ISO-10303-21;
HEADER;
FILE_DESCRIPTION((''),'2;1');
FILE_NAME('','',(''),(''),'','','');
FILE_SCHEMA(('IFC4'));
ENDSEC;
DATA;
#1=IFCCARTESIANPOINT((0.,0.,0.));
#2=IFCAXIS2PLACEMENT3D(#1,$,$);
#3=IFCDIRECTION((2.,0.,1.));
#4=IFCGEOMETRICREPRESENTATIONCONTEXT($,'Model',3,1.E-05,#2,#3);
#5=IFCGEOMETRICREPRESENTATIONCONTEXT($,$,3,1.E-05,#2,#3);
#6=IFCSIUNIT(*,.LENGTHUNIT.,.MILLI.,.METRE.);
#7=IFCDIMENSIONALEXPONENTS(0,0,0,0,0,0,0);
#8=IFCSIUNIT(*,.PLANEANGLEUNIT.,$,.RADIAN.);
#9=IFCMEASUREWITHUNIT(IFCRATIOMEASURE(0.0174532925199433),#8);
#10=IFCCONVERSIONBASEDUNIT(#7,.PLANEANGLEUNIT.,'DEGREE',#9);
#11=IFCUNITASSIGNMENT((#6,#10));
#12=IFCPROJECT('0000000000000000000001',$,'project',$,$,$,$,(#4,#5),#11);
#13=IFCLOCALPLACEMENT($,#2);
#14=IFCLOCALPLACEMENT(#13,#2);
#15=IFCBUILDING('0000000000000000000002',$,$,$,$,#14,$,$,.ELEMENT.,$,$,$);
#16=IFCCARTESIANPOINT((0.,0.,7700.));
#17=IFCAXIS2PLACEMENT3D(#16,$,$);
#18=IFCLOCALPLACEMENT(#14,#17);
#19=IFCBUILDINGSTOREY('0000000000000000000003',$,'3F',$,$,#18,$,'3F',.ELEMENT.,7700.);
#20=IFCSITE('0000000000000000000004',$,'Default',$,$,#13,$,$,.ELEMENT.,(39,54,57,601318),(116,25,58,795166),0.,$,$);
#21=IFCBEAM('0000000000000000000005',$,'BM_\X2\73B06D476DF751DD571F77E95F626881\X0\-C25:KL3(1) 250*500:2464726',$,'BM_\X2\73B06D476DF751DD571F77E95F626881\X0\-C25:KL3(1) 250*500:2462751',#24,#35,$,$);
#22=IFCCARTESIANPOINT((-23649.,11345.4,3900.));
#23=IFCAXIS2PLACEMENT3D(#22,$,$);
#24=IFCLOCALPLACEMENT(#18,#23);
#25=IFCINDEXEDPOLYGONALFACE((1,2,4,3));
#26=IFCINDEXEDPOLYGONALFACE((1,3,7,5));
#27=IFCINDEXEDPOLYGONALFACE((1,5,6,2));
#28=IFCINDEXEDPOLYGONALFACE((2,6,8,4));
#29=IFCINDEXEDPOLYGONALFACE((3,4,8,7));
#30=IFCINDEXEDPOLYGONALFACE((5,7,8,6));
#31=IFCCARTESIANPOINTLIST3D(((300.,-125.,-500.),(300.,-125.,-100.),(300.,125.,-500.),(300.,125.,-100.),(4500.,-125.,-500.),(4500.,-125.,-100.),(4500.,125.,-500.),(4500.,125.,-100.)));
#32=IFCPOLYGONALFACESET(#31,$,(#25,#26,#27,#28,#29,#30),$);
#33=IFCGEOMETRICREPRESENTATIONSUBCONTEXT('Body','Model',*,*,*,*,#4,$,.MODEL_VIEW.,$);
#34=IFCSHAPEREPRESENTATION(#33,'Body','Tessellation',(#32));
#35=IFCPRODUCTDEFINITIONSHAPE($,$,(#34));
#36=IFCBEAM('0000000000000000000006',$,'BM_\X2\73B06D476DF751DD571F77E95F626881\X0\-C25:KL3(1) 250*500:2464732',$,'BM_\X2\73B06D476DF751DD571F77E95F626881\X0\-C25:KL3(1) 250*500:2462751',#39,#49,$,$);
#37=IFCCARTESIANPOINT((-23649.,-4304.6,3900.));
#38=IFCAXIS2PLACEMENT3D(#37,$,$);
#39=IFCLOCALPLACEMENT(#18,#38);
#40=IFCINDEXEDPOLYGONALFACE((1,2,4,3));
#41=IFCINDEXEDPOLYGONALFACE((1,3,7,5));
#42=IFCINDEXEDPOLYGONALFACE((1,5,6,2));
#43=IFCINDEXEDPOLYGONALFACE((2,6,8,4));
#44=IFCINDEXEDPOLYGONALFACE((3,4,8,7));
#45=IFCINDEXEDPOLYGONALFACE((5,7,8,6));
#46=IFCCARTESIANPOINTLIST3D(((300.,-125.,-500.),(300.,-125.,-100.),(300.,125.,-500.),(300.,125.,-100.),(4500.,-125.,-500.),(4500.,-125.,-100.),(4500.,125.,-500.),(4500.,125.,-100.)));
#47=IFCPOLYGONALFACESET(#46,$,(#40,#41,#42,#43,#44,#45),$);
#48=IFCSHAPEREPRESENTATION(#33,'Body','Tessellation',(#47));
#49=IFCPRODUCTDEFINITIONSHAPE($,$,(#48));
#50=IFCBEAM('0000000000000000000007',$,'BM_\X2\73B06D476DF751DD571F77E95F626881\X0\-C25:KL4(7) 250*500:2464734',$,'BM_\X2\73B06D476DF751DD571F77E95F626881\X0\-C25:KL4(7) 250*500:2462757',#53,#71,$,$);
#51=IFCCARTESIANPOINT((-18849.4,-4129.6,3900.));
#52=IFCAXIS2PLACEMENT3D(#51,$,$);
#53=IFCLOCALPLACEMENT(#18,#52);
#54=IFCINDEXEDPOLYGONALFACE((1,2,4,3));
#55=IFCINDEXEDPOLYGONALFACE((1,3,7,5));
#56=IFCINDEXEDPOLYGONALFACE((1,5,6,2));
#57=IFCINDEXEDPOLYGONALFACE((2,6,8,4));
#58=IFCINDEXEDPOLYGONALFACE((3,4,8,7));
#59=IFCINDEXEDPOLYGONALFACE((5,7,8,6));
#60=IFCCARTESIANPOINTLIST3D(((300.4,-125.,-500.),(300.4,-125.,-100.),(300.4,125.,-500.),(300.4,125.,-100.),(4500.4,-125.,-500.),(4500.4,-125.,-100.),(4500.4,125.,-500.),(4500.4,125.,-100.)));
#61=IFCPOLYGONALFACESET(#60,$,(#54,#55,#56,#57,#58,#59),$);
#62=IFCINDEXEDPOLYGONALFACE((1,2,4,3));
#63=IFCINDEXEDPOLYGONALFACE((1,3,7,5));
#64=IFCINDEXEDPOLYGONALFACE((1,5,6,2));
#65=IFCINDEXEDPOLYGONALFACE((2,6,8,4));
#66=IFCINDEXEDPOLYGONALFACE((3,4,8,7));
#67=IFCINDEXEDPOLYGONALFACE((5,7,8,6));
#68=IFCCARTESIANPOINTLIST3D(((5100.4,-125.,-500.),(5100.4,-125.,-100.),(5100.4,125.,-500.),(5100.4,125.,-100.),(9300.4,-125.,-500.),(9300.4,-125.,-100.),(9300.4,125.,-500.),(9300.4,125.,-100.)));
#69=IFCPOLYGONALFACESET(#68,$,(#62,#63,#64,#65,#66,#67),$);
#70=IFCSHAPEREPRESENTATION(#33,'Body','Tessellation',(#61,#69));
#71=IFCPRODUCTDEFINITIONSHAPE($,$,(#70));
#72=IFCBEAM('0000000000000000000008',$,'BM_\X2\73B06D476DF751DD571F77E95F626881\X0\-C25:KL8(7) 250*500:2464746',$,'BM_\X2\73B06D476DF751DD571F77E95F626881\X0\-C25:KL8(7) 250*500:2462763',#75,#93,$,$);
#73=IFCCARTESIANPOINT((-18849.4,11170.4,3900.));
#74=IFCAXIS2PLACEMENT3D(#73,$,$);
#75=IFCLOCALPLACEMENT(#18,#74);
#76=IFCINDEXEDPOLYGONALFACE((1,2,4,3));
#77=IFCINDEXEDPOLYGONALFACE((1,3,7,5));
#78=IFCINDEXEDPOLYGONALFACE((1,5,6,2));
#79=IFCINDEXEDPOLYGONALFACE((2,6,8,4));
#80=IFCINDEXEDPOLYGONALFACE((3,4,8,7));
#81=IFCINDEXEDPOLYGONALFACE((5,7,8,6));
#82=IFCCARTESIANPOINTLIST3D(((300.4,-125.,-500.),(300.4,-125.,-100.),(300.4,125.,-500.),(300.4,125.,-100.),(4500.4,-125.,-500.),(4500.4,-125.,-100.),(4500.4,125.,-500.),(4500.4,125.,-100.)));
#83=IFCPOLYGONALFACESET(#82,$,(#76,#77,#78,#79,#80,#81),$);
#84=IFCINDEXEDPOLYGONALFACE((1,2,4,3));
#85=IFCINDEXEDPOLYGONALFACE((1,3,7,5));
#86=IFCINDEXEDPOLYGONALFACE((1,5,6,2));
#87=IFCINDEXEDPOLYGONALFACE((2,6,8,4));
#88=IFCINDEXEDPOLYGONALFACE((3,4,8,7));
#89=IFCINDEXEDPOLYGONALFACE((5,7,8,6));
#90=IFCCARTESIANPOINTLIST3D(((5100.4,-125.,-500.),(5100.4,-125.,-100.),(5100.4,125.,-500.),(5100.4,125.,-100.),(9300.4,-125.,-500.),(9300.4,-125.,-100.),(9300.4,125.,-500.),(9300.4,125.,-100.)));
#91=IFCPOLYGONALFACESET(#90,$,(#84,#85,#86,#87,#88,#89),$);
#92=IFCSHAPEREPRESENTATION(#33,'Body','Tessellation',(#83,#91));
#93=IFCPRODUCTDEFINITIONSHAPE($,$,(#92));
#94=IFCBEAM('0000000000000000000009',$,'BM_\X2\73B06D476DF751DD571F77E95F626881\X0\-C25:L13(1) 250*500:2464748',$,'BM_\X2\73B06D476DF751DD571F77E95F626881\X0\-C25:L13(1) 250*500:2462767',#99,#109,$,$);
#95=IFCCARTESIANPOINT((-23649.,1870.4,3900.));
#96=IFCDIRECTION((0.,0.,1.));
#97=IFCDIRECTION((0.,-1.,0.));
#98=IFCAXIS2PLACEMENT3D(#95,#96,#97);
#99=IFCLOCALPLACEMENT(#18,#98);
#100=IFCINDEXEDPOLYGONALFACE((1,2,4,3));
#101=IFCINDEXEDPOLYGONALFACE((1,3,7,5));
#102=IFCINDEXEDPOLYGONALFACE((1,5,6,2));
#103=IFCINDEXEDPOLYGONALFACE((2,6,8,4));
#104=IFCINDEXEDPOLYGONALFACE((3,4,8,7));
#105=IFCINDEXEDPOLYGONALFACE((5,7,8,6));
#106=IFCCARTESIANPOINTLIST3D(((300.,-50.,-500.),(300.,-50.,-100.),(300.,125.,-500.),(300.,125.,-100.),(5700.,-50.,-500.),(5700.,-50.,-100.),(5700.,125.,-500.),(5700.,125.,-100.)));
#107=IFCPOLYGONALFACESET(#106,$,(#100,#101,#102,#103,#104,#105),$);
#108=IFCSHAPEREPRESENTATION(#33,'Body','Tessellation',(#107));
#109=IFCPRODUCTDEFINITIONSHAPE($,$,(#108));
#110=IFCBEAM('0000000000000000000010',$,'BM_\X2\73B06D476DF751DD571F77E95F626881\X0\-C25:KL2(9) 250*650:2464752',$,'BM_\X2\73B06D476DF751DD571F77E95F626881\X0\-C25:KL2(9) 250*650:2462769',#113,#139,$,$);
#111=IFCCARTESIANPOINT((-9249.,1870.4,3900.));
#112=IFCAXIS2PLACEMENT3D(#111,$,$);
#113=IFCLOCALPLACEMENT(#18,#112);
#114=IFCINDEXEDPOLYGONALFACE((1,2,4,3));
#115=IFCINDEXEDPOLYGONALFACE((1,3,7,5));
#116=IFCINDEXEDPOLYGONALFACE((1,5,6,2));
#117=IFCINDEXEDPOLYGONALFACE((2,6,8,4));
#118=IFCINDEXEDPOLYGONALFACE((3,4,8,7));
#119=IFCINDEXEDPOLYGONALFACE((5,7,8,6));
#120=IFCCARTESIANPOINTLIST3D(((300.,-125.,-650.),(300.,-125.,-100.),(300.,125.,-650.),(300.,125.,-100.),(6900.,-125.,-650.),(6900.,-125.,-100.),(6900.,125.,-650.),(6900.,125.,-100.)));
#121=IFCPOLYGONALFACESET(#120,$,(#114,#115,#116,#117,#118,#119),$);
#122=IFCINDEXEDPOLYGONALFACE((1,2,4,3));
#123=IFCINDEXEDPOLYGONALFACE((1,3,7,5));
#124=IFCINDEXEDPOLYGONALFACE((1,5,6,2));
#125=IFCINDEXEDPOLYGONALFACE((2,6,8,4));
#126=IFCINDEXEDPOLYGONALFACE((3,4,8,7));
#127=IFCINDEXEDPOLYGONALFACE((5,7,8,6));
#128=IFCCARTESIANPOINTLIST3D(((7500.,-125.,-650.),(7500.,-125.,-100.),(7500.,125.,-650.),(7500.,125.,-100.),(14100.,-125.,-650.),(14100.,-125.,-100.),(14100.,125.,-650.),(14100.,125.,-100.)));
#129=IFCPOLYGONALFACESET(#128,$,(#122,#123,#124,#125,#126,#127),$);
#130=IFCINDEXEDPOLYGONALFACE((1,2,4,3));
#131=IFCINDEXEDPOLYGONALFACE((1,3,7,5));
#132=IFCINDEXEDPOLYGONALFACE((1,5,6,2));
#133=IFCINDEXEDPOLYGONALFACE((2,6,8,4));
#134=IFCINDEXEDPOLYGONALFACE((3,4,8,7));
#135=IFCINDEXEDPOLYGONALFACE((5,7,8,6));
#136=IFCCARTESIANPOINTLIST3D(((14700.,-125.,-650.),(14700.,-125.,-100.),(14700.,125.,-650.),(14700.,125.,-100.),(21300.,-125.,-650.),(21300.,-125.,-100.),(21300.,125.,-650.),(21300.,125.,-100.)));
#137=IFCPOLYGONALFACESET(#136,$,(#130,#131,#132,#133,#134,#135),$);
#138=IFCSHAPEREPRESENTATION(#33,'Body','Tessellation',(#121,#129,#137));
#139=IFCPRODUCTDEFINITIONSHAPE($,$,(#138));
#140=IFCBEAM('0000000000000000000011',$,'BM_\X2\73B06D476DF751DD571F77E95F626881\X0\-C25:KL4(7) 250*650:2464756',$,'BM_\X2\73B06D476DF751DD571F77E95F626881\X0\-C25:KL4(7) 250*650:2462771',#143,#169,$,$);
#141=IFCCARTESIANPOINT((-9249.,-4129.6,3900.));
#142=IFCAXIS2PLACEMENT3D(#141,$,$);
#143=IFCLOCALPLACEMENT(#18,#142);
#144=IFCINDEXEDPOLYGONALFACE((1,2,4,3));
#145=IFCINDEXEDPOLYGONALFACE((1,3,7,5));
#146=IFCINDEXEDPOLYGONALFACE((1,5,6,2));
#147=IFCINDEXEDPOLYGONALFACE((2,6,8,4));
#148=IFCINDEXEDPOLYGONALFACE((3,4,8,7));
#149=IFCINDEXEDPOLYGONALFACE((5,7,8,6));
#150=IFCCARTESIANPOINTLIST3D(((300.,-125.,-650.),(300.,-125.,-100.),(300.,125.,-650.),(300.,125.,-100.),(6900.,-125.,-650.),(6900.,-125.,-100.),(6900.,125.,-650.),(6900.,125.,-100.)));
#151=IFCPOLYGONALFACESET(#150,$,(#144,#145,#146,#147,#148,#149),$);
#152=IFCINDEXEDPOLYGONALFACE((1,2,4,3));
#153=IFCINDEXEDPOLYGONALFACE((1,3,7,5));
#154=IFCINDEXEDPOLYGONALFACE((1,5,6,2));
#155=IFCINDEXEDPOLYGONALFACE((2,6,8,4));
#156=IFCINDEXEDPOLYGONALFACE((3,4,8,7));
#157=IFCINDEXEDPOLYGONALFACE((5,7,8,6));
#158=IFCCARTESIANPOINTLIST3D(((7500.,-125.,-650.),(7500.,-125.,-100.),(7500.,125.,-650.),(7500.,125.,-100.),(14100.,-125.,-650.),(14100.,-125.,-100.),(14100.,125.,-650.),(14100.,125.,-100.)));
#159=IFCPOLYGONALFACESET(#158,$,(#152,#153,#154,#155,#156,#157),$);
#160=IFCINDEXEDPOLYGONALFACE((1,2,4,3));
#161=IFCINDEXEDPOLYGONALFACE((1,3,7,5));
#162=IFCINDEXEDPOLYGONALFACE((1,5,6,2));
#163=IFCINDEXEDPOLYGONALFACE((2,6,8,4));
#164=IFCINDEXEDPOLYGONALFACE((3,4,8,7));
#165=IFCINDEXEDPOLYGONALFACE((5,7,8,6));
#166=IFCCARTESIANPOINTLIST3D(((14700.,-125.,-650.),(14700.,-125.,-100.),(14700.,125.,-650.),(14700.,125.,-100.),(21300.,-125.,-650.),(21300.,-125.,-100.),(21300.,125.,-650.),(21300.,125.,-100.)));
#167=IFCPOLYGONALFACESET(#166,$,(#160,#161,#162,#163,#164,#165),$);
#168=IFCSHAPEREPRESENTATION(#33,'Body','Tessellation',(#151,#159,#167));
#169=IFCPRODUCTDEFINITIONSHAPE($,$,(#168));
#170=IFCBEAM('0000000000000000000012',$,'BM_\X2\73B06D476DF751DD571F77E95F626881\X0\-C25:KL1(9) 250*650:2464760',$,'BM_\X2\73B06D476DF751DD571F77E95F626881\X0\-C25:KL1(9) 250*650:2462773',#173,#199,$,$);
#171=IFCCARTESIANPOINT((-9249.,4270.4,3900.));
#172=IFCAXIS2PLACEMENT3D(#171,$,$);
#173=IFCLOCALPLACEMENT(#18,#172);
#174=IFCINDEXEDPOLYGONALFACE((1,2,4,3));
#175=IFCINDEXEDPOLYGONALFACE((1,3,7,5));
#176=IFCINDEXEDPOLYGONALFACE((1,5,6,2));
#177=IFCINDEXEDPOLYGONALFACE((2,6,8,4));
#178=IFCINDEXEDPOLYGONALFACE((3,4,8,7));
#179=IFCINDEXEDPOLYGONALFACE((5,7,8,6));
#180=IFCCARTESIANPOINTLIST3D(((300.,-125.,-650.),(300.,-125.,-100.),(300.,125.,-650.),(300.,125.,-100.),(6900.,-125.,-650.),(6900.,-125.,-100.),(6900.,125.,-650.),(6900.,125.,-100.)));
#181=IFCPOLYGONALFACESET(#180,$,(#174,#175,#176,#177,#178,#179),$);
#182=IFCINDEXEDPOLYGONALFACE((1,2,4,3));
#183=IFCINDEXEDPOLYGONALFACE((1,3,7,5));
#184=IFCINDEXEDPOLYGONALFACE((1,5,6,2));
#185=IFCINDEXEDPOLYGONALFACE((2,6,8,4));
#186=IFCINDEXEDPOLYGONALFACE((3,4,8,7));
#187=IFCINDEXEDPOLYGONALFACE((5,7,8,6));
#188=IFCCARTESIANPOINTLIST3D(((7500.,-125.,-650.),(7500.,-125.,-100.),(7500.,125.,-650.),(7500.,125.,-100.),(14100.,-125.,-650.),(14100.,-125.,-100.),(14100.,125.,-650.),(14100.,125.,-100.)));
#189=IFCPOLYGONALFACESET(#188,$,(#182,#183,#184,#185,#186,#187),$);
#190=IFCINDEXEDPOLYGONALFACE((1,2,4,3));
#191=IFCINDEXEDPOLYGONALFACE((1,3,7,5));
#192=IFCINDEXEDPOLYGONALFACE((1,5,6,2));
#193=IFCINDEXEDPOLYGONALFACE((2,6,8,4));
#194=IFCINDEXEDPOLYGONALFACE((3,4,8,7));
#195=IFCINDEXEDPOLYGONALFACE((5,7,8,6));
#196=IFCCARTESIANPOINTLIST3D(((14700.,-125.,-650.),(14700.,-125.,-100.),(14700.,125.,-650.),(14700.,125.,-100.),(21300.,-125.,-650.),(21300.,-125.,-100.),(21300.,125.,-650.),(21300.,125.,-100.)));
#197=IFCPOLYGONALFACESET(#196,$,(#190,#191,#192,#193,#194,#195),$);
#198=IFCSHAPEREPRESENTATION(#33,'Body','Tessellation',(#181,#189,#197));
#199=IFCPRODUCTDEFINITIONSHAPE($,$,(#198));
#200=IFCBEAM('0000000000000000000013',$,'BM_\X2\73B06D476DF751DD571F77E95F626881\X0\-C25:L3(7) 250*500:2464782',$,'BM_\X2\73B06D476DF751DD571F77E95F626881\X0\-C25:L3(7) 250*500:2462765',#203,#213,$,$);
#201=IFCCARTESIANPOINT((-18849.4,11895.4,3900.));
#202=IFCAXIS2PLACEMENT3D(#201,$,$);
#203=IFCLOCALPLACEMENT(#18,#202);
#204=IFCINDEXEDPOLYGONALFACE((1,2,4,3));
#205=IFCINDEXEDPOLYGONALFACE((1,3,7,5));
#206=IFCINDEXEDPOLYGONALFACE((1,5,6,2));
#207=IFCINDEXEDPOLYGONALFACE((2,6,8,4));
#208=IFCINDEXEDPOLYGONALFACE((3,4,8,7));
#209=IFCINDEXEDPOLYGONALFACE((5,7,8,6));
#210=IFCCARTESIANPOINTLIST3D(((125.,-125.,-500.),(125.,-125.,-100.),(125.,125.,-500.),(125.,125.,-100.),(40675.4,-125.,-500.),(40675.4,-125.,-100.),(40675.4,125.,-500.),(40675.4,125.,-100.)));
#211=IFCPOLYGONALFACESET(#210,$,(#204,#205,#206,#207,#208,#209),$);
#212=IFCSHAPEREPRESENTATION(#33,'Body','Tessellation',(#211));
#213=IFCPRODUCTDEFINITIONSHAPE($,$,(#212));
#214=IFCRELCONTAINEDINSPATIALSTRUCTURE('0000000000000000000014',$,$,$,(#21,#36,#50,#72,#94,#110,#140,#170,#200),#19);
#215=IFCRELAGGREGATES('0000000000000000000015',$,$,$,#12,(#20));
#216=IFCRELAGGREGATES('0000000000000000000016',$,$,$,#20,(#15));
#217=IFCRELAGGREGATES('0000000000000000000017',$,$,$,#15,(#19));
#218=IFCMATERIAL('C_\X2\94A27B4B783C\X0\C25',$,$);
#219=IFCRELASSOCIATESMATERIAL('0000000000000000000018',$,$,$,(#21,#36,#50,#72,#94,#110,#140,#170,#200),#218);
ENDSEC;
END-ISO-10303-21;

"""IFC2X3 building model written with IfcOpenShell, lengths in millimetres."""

from ifc_helpers import new_model, entity, si_unit, converted_unit, direction, frame, frame_2d, origin, origin_2d_with_axis, place, context, subcontext, project, spatial, rectangle, extrude, material, element, save


model = new_model("IFC2X3")

# Units and contexts
model_context = context("Model", 3, precision=1e-05, world=origin(), true_north=direction((2.0, 0.0, 1.0)))
context_of_model = context(None, 3, precision=1e-05, world=origin(), true_north=direction((2.0, 0.0, 1.0)))
body_context = subcontext(model_context, "Body", "Model", "MODEL_VIEW")
ifc_project = project(units=[si_unit("LENGTHUNIT", "METRE", prefix="MILLI"), converted_unit("PLANEANGLEUNIT", "DEGREE", entity("IfcRatioMeasure", 0.0174532925199433), si_unit("PLANEANGLEUNIT", "RADIAN"), dimensions=[0, 0, 0, 0, 0, 0, 0])], contexts=[model_context, context_of_model])

# Site, building, storey
site_placement = place(None, origin())
site = spatial("IfcSite", under=ifc_project, at=site_placement, Name="Default", CompositionType="ELEMENT", RefLatitude=(39, 54, 57, 601318), RefLongitude=(116, 25, 58, 795166), RefElevation=0.0)
building_placement = place(site_placement, origin())
building = spatial("IfcBuilding", under=site, at=building_placement, CompositionType="ELEMENT")
storey_placement = place(building_placement, frame((0.0, 0.0, 7700.0)))
storey = spatial("IfcBuildingStorey", under=building, at=storey_placement, Name="3F", LongName="3F", CompositionType="ELEMENT", Elevation=7700.0)

# Beams
ifc_material = material(Name="C_钢筋砼C25")
beam_1_placement = place(storey_placement, frame((-23649.0, 11345.4, 3900.0)))
element("IfcBeam", 1, at=beam_1_placement, inside=storey, material=ifc_material, Name="BM_现浇混凝土矩形梁-C25:KL3(1) 250*500:2464726", ObjectType="BM_现浇混凝土矩形梁-C25:KL3(1) 250*500:2462751", context=body_context, shape_type="SweptSolid", body=[
    extrude(rectangle(XDim=400.0, YDim=250.0, at=frame_2d((0.0, 0.0), x_axis=(1.0, 0.0))), frame((300.0, 0.0, -300.0), z_axis=(1.0, 0.0, 0.0), x_axis=(0.0, 0.0, -1.0)), (0.0, 0.0, 1.0), 4200.0),
])
beam_2_placement = place(storey_placement, frame((-23649.0, -4304.6, 3900.0)))
element("IfcBeam", 2, at=beam_2_placement, inside=storey, material=ifc_material, Name="BM_现浇混凝土矩形梁-C25:KL3(1) 250*500:2464732", ObjectType="BM_现浇混凝土矩形梁-C25:KL3(1) 250*500:2462751", context=body_context, shape_type="SweptSolid", body=[
    extrude(rectangle(XDim=400.0, YDim=250.0, at=frame_2d((0.0, 0.0), x_axis=(1.0, 0.0))), frame((300.0, 0.0, -300.0), z_axis=(1.0, 0.0, 0.0), x_axis=(0.0, 0.0, -1.0)), (0.0, 0.0, 1.0), 4200.0),
])
beam_3_placement = place(storey_placement, frame((-18849.4, -4129.6, 3900.0)))
element("IfcBeam", 3, at=beam_3_placement, inside=storey, material=ifc_material, Name="BM_现浇混凝土矩形梁-C25:KL4(7) 250*500:2464734", ObjectType="BM_现浇混凝土矩形梁-C25:KL4(7) 250*500:2462757", context=body_context, shape_type="SweptSolid", body=[
    extrude(rectangle(XDim=400.0, YDim=250.0, at=frame_2d((0.0, 0.0), x_axis=(1.0, 0.0))), frame((300.4, 0.0, -300.0), z_axis=(1.0, 0.0, 0.0), x_axis=(0.0, 0.0, 1.0)), (0.0, 0.0, 1.0), 4200.0),
    extrude(rectangle(XDim=400.0, YDim=250.0, at=origin_2d_with_axis()), frame((5100.4, 0.0, -300.0), z_axis=(1.0, 0.0, 0.0), x_axis=(0.0, 0.0, 1.0)), (0.0, 0.0, 1.0), 4200.0),
])
beam_4_placement = place(storey_placement, frame((-18849.4, 11170.4, 3900.0)))
element("IfcBeam", 4, at=beam_4_placement, inside=storey, material=ifc_material, Name="BM_现浇混凝土矩形梁-C25:KL8(7) 250*500:2464746", ObjectType="BM_现浇混凝土矩形梁-C25:KL8(7) 250*500:2462763", context=body_context, shape_type="SweptSolid", body=[
    extrude(rectangle(XDim=400.0, YDim=250.0, at=origin_2d_with_axis()), frame((300.4, 0.0, -300.0), z_axis=(1.0, 0.0, 0.0), x_axis=(0.0, 0.0, 1.0)), (0.0, 0.0, 1.0), 4200.0),
    extrude(rectangle(XDim=400.0, YDim=250.0, at=origin_2d_with_axis()), frame((5100.4, 0.0, -300.0), z_axis=(1.0, 0.0, 0.0), x_axis=(0.0, 0.0, 1.0)), (0.0, 0.0, 1.0), 4200.0),
])
beam_5_placement = place(storey_placement, frame((-23649.0, 1870.4, 3900.0), z_axis=(0.0, 0.0, 1.0), x_axis=(0.0, -1.0, 0.0)))
element("IfcBeam", 5, at=beam_5_placement, inside=storey, material=ifc_material, Name="BM_现浇混凝土矩形梁-C25:L13(1) 250*500:2464748", ObjectType="BM_现浇混凝土矩形梁-C25:L13(1) 250*500:2462767", context=body_context, shape_type="SweptSolid", body=[
    extrude(rectangle(XDim=400.0, YDim=175.0, at=origin_2d_with_axis()), frame((300.0, 37.5, -300.0), z_axis=(1.0, 0.0, 0.0), x_axis=(0.0, 0.0, -1.0)), (0.0, 0.0, 1.0), 5400.0),
])
beam_6_placement = place(storey_placement, frame((-9249.0, 1870.4, 3900.0)))
element("IfcBeam", 6, at=beam_6_placement, inside=storey, material=ifc_material, Name="BM_现浇混凝土矩形梁-C25:KL2(9) 250*650:2464752", ObjectType="BM_现浇混凝土矩形梁-C25:KL2(9) 250*650:2462769", context=body_context, shape_type="SweptSolid", body=[
    extrude(rectangle(XDim=550.0, YDim=250.0, at=frame_2d((0.0, 0.0), x_axis=(1.0, 0.0))), frame((300.0, 0.0, -375.0), z_axis=(1.0, 0.0, 0.0), x_axis=(0.0, 0.0, 1.0)), (0.0, 0.0, 1.0), 6600.0),
    extrude(rectangle(XDim=550.0, YDim=250.0, at=frame_2d((0.0, 0.0), x_axis=(1.0, 0.0))), frame((7500.0, 0.0, -375.0), z_axis=(1.0, 0.0, 0.0), x_axis=(0.0, 0.0, 1.0)), (0.0, 0.0, 1.0), 6600.0),
    extrude(rectangle(XDim=550.0, YDim=250.0, at=frame_2d((0.0, 0.0), x_axis=(1.0, 0.0))), frame((14700.0, 0.0, -375.0), z_axis=(1.0, 0.0, 0.0), x_axis=(0.0, 0.0, 1.0)), (0.0, 0.0, 1.0), 6600.0),
])
beam_7_placement = place(storey_placement, frame((-9249.0, -4129.6, 3900.0)))
element("IfcBeam", 7, at=beam_7_placement, inside=storey, material=ifc_material, Name="BM_现浇混凝土矩形梁-C25:KL4(7) 250*650:2464756", ObjectType="BM_现浇混凝土矩形梁-C25:KL4(7) 250*650:2462771", context=body_context, shape_type="SweptSolid", body=[
    extrude(rectangle(XDim=550.0, YDim=250.0, at=frame_2d((0.0, 0.0), x_axis=(1.0, 0.0))), frame((300.0, 0.0, -375.0), z_axis=(1.0, 0.0, 0.0), x_axis=(0.0, 0.0, 1.0)), (0.0, 0.0, 1.0), 6600.0),
    extrude(rectangle(XDim=550.0, YDim=250.0, at=frame_2d((0.0, 0.0), x_axis=(1.0, 0.0))), frame((7500.0, 0.0, -375.0), z_axis=(1.0, 0.0, 0.0), x_axis=(0.0, 0.0, 1.0)), (0.0, 0.0, 1.0), 6600.0),
    extrude(rectangle(XDim=550.0, YDim=250.0, at=frame_2d((0.0, 0.0), x_axis=(1.0, 0.0))), frame((14700.0, 0.0, -375.0), z_axis=(1.0, 0.0, 0.0), x_axis=(0.0, 0.0, 1.0)), (0.0, 0.0, 1.0), 6600.0),
])
beam_8_placement = place(storey_placement, frame((-9249.0, 4270.4, 3900.0)))
element("IfcBeam", 8, at=beam_8_placement, inside=storey, material=ifc_material, Name="BM_现浇混凝土矩形梁-C25:KL1(9) 250*650:2464760", ObjectType="BM_现浇混凝土矩形梁-C25:KL1(9) 250*650:2462773", context=body_context, shape_type="SweptSolid", body=[
    extrude(rectangle(XDim=550.0, YDim=250.0, at=frame_2d((0.0, 0.0), x_axis=(1.0, 0.0))), frame((300.0, 0.0, -375.0), z_axis=(1.0, 0.0, 0.0), x_axis=(0.0, 0.0, 1.0)), (0.0, 0.0, 1.0), 6600.0),
    extrude(rectangle(XDim=550.0, YDim=250.0, at=frame_2d((0.0, 0.0), x_axis=(1.0, 0.0))), frame((7500.0, 0.0, -375.0), z_axis=(1.0, 0.0, 0.0), x_axis=(0.0, 0.0, 1.0)), (0.0, 0.0, 1.0), 6600.0),
    extrude(rectangle(XDim=550.0, YDim=250.0, at=frame_2d((-45.0, 25.0), x_axis=(1.0, 0.0))), frame((14700.0, 25.0, -330.0), z_axis=(1.0, 0.0, 0.0), x_axis=(0.0, 0.0, 1.0)), (0.0, 0.0, 1.0), 6600.0),
])
beam_9_placement = place(storey_placement, frame((-18849.4, 11895.4, 3900.0)))
element("IfcBeam", 9, at=beam_9_placement, inside=storey, material=ifc_material, Name="BM_现浇混凝土矩形梁-C25:L3(7) 250*500:2464782", ObjectType="BM_现浇混凝土矩形梁-C25:L3(7) 250*500:2462765", context=body_context, shape_type="SweptSolid", body=[
    extrude(rectangle(XDim=400.0, YDim=250.0, at=frame_2d((0.0, 0.0), x_axis=(1.0, 0.0))), frame((125.0, 0.0, -300.0), z_axis=(1.0, 0.0, 0.0), x_axis=(0.0, 0.0, -1.0)), (0.0, 0.0, 1.0), 40550.4),
])

save(model, "model.ifc")
